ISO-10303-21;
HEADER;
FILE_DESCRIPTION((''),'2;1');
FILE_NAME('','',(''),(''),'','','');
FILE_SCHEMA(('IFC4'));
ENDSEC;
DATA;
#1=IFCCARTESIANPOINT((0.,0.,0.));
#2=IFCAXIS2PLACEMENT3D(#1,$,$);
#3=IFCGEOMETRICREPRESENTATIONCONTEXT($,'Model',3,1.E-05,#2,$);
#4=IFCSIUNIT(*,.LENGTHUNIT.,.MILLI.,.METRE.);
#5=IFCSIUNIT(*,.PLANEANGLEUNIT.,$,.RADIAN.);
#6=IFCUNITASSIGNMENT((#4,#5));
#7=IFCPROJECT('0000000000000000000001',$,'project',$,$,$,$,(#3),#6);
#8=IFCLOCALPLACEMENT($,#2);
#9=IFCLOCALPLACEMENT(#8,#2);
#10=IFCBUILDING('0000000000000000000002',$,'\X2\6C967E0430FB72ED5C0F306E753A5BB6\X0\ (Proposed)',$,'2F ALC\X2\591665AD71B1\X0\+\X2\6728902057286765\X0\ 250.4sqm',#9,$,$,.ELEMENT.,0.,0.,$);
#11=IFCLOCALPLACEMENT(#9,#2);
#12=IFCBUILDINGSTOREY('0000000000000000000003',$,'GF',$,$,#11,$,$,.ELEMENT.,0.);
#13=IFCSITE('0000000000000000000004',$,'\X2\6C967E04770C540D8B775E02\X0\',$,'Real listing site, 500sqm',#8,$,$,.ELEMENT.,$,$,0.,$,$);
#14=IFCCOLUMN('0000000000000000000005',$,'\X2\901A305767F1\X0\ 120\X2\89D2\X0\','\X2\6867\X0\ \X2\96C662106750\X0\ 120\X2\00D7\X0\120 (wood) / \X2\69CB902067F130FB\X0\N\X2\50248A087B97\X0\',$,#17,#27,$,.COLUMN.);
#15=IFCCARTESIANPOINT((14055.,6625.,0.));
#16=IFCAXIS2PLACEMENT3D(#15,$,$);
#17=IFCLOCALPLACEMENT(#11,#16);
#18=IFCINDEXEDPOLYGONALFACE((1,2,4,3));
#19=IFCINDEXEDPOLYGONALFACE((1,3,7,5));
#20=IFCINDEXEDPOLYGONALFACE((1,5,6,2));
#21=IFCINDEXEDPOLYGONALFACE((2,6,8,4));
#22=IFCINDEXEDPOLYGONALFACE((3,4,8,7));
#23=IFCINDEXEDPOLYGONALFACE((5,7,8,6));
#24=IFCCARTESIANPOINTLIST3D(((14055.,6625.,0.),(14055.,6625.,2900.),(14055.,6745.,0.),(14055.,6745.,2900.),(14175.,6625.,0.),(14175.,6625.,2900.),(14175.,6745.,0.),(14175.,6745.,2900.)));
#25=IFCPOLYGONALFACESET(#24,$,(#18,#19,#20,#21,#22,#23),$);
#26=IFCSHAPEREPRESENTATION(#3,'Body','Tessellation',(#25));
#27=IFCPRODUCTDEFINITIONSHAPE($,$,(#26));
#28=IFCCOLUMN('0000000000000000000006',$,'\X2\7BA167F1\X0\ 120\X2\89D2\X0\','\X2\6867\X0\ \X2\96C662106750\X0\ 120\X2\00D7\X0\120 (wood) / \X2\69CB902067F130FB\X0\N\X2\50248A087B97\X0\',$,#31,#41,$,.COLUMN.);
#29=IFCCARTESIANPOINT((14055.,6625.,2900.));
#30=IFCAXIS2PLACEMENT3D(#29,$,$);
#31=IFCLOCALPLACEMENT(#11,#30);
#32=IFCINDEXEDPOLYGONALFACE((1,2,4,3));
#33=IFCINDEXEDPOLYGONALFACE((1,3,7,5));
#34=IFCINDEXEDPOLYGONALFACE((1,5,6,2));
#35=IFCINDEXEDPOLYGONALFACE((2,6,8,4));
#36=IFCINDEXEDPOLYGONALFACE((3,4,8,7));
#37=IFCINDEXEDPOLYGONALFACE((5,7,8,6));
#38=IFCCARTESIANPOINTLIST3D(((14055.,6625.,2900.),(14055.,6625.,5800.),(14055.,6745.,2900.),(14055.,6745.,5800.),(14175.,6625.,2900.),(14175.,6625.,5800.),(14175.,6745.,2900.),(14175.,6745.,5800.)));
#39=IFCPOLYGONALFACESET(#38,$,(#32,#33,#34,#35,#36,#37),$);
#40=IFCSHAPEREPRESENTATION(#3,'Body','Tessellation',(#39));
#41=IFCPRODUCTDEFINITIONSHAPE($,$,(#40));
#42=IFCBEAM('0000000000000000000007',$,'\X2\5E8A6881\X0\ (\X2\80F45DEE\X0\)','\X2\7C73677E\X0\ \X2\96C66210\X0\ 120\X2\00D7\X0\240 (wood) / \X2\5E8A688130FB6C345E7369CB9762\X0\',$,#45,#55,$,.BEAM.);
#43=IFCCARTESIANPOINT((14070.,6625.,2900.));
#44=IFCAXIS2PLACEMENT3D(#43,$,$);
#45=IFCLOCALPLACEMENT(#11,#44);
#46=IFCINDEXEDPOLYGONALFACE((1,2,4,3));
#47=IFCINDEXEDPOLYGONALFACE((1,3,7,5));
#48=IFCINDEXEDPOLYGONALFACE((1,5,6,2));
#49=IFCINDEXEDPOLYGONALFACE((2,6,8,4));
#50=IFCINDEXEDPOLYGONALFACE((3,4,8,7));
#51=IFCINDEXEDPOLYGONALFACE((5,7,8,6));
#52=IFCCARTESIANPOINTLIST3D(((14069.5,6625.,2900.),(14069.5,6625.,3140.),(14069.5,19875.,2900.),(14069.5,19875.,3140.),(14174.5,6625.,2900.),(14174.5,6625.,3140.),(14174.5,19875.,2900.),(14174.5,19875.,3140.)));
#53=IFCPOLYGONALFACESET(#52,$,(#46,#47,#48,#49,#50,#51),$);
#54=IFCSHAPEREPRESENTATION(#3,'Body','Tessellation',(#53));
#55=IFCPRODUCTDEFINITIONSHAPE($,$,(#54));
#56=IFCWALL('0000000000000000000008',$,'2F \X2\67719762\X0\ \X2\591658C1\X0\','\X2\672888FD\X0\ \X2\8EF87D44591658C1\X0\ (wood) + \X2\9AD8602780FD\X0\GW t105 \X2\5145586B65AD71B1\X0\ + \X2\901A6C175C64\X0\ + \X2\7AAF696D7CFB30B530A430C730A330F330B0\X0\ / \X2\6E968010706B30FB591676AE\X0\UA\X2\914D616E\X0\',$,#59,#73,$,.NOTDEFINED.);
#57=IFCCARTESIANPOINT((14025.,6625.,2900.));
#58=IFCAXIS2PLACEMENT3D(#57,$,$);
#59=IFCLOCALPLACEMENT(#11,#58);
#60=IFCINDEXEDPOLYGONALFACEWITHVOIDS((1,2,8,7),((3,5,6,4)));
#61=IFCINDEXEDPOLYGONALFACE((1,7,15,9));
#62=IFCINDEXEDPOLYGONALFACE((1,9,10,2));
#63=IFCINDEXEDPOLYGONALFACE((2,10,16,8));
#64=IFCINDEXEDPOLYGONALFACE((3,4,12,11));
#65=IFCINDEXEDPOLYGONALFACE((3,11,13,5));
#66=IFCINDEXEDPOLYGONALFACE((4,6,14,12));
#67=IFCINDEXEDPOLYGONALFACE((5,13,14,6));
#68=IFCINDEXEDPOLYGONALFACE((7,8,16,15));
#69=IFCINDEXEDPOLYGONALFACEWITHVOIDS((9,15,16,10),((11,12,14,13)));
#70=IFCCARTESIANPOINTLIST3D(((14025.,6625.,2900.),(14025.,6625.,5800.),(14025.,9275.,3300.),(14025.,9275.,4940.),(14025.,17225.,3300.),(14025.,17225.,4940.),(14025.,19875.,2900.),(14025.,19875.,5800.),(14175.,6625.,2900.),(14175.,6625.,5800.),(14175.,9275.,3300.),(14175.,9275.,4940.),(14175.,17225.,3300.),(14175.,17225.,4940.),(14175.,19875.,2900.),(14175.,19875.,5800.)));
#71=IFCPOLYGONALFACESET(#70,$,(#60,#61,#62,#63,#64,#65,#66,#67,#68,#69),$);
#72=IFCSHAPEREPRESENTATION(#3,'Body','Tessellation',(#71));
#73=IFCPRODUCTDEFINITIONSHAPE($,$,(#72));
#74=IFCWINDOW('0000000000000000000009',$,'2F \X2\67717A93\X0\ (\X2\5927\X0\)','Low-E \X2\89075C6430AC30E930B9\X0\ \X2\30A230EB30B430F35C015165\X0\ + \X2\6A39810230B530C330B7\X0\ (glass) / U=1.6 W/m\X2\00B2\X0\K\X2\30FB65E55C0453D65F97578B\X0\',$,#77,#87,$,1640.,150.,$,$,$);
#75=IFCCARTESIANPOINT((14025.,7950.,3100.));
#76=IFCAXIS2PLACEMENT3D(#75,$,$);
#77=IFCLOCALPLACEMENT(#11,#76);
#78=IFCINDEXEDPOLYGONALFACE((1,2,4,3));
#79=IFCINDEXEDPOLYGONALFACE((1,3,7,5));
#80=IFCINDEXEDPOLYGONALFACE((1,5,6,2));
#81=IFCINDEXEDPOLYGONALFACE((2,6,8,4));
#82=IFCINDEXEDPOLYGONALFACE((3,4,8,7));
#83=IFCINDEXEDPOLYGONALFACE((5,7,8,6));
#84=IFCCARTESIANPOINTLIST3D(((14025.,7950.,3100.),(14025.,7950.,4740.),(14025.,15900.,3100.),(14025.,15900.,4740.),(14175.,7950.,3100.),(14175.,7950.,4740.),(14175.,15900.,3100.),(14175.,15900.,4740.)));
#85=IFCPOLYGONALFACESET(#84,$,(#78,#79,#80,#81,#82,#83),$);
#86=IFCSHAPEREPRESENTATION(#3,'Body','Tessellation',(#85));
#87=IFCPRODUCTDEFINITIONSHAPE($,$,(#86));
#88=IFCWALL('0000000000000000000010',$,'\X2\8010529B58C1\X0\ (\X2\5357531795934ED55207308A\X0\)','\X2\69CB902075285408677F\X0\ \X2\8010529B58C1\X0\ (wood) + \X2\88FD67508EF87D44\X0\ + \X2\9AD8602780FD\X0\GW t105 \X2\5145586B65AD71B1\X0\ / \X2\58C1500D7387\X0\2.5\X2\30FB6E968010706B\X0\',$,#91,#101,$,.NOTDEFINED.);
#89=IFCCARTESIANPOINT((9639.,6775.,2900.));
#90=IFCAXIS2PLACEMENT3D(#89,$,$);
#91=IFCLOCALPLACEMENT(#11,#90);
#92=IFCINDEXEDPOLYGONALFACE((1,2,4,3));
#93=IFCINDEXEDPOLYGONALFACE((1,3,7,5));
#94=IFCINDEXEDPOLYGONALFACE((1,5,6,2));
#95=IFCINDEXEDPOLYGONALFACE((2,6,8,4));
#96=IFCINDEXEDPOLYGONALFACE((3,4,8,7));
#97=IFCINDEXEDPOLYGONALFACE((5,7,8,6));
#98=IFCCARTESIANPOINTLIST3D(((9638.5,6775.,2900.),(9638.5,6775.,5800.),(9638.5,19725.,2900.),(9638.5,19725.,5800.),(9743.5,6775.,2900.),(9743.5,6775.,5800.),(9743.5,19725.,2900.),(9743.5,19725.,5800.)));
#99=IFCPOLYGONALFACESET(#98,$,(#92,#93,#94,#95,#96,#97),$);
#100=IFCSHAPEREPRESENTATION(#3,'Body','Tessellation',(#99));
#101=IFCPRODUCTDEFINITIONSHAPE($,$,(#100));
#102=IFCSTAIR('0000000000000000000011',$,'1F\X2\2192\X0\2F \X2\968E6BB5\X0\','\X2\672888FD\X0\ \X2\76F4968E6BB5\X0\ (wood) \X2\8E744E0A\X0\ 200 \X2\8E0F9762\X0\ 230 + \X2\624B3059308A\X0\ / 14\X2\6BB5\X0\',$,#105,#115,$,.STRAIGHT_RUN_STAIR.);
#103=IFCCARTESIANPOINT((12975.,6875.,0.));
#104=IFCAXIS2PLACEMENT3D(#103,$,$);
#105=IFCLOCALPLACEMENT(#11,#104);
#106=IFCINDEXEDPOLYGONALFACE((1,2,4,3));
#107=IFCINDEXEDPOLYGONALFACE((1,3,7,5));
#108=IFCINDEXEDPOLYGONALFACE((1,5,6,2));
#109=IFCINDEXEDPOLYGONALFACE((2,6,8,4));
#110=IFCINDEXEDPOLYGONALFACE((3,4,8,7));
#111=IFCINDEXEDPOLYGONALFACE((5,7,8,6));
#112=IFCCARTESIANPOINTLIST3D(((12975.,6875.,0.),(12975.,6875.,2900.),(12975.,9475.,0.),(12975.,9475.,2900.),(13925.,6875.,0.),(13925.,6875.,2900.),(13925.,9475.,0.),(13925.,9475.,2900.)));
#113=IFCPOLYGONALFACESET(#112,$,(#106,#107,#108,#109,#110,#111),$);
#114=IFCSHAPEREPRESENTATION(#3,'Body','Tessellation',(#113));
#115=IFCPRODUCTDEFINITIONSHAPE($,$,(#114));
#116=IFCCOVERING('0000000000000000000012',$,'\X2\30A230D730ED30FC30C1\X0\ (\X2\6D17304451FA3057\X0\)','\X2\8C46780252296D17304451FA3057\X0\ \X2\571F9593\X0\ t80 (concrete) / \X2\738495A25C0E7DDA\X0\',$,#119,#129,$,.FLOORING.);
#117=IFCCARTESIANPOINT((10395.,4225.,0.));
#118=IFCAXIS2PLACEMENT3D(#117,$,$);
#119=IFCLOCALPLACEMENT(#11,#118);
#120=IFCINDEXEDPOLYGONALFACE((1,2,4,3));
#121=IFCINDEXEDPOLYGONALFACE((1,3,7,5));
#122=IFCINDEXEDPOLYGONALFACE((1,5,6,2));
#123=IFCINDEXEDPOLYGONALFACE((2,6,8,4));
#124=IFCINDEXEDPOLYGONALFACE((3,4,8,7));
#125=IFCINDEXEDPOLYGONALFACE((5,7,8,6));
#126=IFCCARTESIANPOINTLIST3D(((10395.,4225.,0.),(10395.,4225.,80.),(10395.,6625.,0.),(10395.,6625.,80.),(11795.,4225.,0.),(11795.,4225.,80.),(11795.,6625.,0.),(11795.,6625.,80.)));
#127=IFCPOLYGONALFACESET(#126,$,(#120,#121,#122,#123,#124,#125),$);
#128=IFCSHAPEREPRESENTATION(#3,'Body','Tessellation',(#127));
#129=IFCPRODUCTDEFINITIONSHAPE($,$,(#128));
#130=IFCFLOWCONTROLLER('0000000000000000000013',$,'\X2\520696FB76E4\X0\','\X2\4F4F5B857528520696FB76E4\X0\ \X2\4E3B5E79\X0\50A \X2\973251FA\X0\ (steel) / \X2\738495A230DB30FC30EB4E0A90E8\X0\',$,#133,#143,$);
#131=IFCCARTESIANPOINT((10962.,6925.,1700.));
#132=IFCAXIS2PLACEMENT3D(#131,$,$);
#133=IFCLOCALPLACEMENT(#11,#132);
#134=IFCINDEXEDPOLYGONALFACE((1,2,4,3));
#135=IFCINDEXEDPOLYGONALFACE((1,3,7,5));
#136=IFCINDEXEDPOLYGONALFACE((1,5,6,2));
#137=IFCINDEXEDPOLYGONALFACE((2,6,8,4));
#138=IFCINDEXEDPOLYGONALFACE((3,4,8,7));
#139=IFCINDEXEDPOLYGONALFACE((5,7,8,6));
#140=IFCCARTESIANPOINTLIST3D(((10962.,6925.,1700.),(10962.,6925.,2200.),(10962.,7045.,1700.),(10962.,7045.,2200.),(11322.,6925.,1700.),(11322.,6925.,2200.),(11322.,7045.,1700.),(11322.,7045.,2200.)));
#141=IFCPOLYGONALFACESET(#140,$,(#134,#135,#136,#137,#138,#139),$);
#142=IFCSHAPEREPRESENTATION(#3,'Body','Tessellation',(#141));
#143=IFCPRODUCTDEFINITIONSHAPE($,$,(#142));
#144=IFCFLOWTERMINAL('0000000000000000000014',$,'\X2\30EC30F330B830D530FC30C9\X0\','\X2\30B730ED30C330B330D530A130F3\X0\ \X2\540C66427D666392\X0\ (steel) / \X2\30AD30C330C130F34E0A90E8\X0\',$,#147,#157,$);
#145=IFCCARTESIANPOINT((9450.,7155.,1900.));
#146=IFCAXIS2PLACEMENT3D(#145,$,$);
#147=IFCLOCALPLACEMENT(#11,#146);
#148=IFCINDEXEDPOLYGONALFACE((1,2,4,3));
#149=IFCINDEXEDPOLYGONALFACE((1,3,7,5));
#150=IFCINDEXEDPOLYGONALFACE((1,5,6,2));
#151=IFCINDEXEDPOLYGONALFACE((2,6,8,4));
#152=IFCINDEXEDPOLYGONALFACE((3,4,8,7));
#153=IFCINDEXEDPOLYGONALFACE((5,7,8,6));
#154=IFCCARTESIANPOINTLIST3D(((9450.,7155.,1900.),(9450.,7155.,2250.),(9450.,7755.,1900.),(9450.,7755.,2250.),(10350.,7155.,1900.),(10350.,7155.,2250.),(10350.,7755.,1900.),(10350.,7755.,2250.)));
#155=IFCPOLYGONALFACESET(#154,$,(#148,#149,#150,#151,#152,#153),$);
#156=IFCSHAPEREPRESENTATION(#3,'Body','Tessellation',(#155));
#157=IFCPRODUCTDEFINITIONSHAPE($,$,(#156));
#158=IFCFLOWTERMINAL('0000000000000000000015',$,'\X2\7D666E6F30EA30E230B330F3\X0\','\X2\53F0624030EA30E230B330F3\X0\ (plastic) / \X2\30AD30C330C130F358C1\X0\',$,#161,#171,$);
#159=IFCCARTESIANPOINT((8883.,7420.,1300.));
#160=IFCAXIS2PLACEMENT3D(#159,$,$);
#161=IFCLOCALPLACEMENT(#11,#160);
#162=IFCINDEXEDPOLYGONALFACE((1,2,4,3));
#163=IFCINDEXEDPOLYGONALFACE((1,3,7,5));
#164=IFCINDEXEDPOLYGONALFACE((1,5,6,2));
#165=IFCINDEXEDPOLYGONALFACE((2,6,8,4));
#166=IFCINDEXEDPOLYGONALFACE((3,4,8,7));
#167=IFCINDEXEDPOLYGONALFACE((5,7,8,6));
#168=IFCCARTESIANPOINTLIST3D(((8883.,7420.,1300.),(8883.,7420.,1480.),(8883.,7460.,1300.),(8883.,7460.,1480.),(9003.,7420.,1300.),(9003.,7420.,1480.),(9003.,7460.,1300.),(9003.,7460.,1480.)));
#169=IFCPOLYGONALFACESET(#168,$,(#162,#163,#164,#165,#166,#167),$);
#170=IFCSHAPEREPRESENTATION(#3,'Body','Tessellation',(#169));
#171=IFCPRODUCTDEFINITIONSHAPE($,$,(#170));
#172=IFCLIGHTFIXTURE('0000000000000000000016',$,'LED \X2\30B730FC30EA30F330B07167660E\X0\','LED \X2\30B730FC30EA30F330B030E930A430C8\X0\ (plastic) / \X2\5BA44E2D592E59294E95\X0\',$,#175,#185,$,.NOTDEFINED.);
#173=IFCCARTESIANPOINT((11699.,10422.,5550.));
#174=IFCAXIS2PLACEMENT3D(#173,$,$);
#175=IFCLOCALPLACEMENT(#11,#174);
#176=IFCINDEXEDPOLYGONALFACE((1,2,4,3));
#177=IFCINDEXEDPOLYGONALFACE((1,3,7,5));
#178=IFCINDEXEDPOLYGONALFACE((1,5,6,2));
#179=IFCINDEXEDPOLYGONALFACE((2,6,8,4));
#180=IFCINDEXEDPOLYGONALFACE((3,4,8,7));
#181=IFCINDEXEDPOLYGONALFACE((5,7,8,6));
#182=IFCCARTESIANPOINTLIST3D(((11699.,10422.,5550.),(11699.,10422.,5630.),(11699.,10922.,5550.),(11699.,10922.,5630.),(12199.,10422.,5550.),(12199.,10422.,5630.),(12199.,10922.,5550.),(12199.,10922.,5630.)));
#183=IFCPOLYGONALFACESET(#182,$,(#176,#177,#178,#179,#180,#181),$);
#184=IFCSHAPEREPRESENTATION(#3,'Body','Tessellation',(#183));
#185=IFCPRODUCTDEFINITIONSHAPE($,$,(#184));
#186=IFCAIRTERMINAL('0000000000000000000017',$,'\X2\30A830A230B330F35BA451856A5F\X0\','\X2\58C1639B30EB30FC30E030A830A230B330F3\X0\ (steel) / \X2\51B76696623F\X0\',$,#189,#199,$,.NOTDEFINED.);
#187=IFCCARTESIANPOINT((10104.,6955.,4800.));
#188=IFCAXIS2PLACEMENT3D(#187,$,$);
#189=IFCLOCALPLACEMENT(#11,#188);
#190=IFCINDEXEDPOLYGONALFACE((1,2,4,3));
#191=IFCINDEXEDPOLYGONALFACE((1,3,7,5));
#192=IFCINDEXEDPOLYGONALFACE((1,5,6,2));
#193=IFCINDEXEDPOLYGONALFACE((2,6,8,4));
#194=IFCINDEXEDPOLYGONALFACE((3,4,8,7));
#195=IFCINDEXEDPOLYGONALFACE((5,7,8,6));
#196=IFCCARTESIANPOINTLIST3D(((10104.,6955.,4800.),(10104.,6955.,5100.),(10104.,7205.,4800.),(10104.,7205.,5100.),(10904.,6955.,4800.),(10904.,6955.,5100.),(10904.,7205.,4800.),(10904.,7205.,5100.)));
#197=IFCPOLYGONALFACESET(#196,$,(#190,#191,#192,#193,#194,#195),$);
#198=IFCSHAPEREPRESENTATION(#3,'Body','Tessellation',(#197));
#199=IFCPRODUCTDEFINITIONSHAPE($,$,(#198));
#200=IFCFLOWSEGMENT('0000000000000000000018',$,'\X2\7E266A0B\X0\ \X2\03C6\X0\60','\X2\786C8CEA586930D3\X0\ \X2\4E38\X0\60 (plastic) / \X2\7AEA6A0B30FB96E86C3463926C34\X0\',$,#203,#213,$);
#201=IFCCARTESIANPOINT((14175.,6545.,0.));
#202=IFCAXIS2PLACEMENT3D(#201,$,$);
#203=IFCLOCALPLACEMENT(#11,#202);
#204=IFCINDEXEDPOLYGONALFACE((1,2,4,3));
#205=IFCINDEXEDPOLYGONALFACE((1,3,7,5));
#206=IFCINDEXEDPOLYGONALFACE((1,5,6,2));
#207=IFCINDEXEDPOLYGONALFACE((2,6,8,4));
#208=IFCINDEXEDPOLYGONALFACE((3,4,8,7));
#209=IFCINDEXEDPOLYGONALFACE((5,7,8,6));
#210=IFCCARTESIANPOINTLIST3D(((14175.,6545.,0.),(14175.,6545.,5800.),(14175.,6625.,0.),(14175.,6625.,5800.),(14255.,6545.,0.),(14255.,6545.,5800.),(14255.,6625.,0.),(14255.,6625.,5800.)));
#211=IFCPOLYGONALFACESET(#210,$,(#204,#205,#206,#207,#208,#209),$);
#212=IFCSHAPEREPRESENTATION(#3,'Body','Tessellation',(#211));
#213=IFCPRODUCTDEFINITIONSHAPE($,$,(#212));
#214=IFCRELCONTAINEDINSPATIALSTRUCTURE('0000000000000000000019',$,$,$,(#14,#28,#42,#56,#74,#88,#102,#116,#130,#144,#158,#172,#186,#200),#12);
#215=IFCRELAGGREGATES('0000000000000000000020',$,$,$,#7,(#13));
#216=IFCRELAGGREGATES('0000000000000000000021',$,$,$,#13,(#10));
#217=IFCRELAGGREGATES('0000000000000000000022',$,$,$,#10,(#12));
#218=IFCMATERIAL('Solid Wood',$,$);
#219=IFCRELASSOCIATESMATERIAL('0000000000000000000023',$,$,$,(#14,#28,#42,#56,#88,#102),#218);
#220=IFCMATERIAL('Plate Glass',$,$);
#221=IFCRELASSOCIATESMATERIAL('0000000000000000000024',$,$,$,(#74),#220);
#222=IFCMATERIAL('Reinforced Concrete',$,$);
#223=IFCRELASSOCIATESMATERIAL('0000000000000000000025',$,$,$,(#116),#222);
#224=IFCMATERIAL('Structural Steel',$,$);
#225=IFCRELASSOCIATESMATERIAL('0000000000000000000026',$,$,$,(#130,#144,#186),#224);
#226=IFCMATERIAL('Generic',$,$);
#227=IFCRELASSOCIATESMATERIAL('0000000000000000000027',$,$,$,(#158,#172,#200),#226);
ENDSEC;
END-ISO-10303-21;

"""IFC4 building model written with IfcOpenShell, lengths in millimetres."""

from ifc_helpers import new_model, si_unit, frame, frame_2d, origin, place, context, project, spatial, rectangle, extrude, material, element, fill, save


model = new_model("IFC4")

# Units and contexts
model_context = context("Model", 3, precision=1e-05, world=origin())
ifc_project = project(units=[si_unit("LENGTHUNIT", "METRE", prefix="MILLI"), si_unit("PLANEANGLEUNIT", "RADIAN")], contexts=[model_context])

# Site, building, storey
site_placement = place(None, origin())
site = spatial("IfcSite", under=ifc_project, at=site_placement, Name="沖縄県名護市", ObjectType="Real listing site, 500sqm", CompositionType="ELEMENT", RefElevation=0.0)
building_placement = place(site_placement, origin())
building = spatial("IfcBuilding", under=site, at=building_placement, Name="沖縄・狭小の町家 (Proposed)", ObjectType="2F ALC外断熱+木造在来 250.4sqm", CompositionType="ELEMENT", ElevationOfRefHeight=0.0, ElevationOfTerrain=0.0)
storey_placement = place(building_placement, origin())
storey = spatial("IfcBuildingStorey", under=building, at=storey_placement, Name="GF", CompositionType="ELEMENT", Elevation=0.0)

# Columns
ifc_material_1 = material(Name="Solid Wood")
column_1_placement = place(storey_placement, frame((14055.0, 6625.0, 0.0)))
element("IfcColumn", 1, at=column_1_placement, inside=storey, material=ifc_material_1, Name="通し柱 120角", Description="桧 集成材 120×120 (wood) / 構造柱・N値計算", PredefinedType="COLUMN", context=model_context, shape_type="SweptSolid", body=[
    extrude(rectangle(XDim=120.0, YDim=120.0, at=frame_2d((60.0, 60.0))), frame((14055.0, 6625.0, 0.0)), (0.0, 0.0, 1.0), 2900.0),
])
column_2_placement = place(storey_placement, frame((14055.0, 6625.0, 2900.0)))
element("IfcColumn", 2, at=column_2_placement, inside=storey, material=ifc_material_1, Name="管柱 120角", Description="桧 集成材 120×120 (wood) / 構造柱・N値計算", PredefinedType="COLUMN", context=model_context, shape_type="SweptSolid", body=[
    extrude(rectangle(XDim=120.0, YDim=120.0, at=frame_2d((60.0, 60.0))), frame((14055.0, 6625.0, 2900.0)), (0.0, 0.0, 1.0), 2900.0),
])

# Beam
beam_1_placement = place(storey_placement, frame((14070.0, 6625.0, 2900.0)))
element("IfcBeam", 3, at=beam_1_placement, inside=storey, material=ifc_material_1, Name="床梁 (胴差)", Description="米松 集成 120×240 (wood) / 床梁・水平構面", PredefinedType="BEAM", context=model_context, shape_type="SweptSolid", body=[
    extrude(rectangle(XDim=105.0, YDim=13250.0, at=frame_2d((52.0, 6625.0))), frame((14070.0, 6625.0, 2900.0)), (0.0, 0.0, 1.0), 240.0),
])

# Shared definitions
ifc_material_2 = material(Name="Plate Glass")

# Wall, opening, window
wall_1_placement = place(storey_placement, frame((14025.0, 6625.0, 2900.0)))
wall_1 = element("IfcWall", 4, at=wall_1_placement, inside=storey, material=ifc_material_1, Name="2F 東面 外壁", Description="木製 軸組外壁 (wood) + 高性能GW t105 充填断熱 + 通気層 + 窯業系サイディング / 準耐火・外皮UA配慮", PredefinedType="NOTDEFINED", context=model_context, shape_type="SweptSolid", body=[
    extrude(rectangle(XDim=150.0, YDim=13250.0, at=frame_2d((75.0, 6625.0))), frame((14025.0, 6625.0, 2900.0)), (0.0, 0.0, 1.0), 2900.0),
])
opening_1_placement = place(storey_placement, frame((14025.0, 7950.0, 3100.0)))
opening_1 = element("IfcOpeningElement", 5, at=opening_1_placement, cuts=wall_1, PredefinedType="NOTDEFINED", context=model_context, shape_type="SweptSolid", body=[
    extrude(rectangle(XDim=150.0, YDim=7950.0, at=frame_2d((75.0, 3975.0))), frame((14025.0, 7950.0, 3100.0)), (0.0, 0.0, 1.0), 1640.0),
])
window_1_placement = place(storey_placement, frame((14025.0, 7950.0, 3100.0)))
window_1 = element("IfcWindow", 6, at=window_1_placement, inside=storey, material=ifc_material_2, Name="2F 東窓 (大)", Description="Low-E 複層ガラス アルゴン封入 + 樹脂サッシ (glass) / U=1.6 W/m²K・日射取得型", OverallHeight=1640.0, OverallWidth=150.0, context=model_context, shape_type="SweptSolid", body=[
    extrude(rectangle(XDim=150.0, YDim=7950.0, at=frame_2d((75.0, 3975.0))), frame((14025.0, 7950.0, 3100.0)), (0.0, 0.0, 1.0), 1640.0),
])
fill(opening_1, window_1)

# Wall
wall_2_placement = place(storey_placement, frame((9639.0, 6775.0, 2900.0)))
element("IfcWall", 7, at=wall_2_placement, inside=storey, material=ifc_material_1, Name="耐力壁 (南北間仕切り)", Description="構造用合板 耐力壁 (wood) + 製材軸組 + 高性能GW t105 充填断熱 / 壁倍率2.5・準耐火", PredefinedType="NOTDEFINED", context=model_context, shape_type="SweptSolid", body=[
    extrude(rectangle(XDim=105.0, YDim=12950.0, at=frame_2d((52.0, 6475.0))), frame((9639.0, 6775.0, 2900.0)), (0.0, 0.0, 1.0), 2900.0),
])

# Stair
stair_placement = place(storey_placement, frame((12975.0, 6875.0, 0.0)))
element("IfcStair", 8, at=stair_placement, inside=storey, material=ifc_material_1, Name="1F→2F 階段", Description="木製 直階段 (wood) 蹴上 200 踏面 230 + 手すり / 14段", PredefinedType="STRAIGHT_RUN_STAIR", context=model_context, shape_type="SweptSolid", body=[
    extrude(rectangle(XDim=950.0, YDim=2600.0, at=frame_2d((475.0, 1300.0))), frame((12975.0, 6875.0, 0.0)), (0.0, 0.0, 1.0), 2900.0),
])

# Covering
ifc_material_3 = material(Name="Reinforced Concrete")
covering_placement = place(storey_placement, frame((10395.0, 4225.0, 0.0)))
element("IfcCovering", 9, at=covering_placement, inside=storey, material=ifc_material_3, Name="アプローチ (洗い出し)", Description="豆砂利洗い出し 土間 t80 (concrete) / 玄関導線", PredefinedType="FLOORING", context=model_context, shape_type="SweptSolid", body=[
    extrude(rectangle(XDim=1400.0, YDim=2400.0, at=frame_2d((700.0, 1200.0))), frame((10395.0, 4225.0, 0.0)), (0.0, 0.0, 1.0), 80.0),
])

# Flow controller
ifc_material_4 = material(Name="Structural Steel")
flow_controller_placement = place(storey_placement, frame((10962.0, 6925.0, 1700.0)))
element("IfcFlowController", 10, at=flow_controller_placement, inside=storey, material=ifc_material_4, Name="分電盤", Description="住宅用分電盤 主幹50A 露出 (steel) / 玄関ホール上部", context=model_context, shape_type="SweptSolid", body=[
    extrude(rectangle(XDim=360.0, YDim=120.0, at=frame_2d((180.0, 60.0))), frame((10962.0, 6925.0, 1700.0)), (0.0, 0.0, 1.0), 500.0),
])

# Flow terminals
flow_terminal_1_placement = place(storey_placement, frame((9450.0, 7155.0, 1900.0)))
element("IfcFlowTerminal", 11, at=flow_terminal_1_placement, inside=storey, material=ifc_material_4, Name="レンジフード", Description="シロッコファン 同時給排 (steel) / キッチン上部", context=model_context, shape_type="SweptSolid", body=[
    extrude(rectangle(XDim=900.0, YDim=600.0, at=frame_2d((450.0, 300.0))), frame((9450.0, 7155.0, 1900.0)), (0.0, 0.0, 1.0), 350.0),
])
ifc_material_5 = material(Name="Generic")
flow_terminal_2_placement = place(storey_placement, frame((8883.0, 7420.0, 1300.0)))
element("IfcFlowTerminal", 12, at=flow_terminal_2_placement, inside=storey, material=ifc_material_5, Name="給湯リモコン", Description="台所リモコン (plastic) / キッチン壁", context=model_context, shape_type="SweptSolid", body=[
    extrude(rectangle(XDim=120.0, YDim=40.0, at=frame_2d((60.0, 20.0))), frame((8883.0, 7420.0, 1300.0)), (0.0, 0.0, 1.0), 180.0),
])

# Light fixture
light_fixture_placement = place(storey_placement, frame((11699.0, 10422.0, 5550.0)))
element("IfcLightFixture", 13, at=light_fixture_placement, inside=storey, material=ifc_material_5, Name="LED シーリング照明", Description="LED シーリングライト (plastic) / 室中央天井", PredefinedType="NOTDEFINED", context=model_context, shape_type="SweptSolid", body=[
    extrude(rectangle(XDim=500.0, YDim=500.0, at=frame_2d((250.0, 250.0))), frame((11699.0, 10422.0, 5550.0)), (0.0, 0.0, 1.0), 80.0),
])

# Air terminal
air_terminal_placement = place(storey_placement, frame((10104.0, 6955.0, 4800.0)))
element("IfcAirTerminal", 14, at=air_terminal_placement, inside=storey, material=ifc_material_4, Name="エアコン室内機", Description="壁掛ルームエアコン (steel) / 冷暖房", PredefinedType="NOTDEFINED", context=model_context, shape_type="SweptSolid", body=[
    extrude(rectangle(XDim=800.0, YDim=250.0, at=frame_2d((400.0, 125.0))), frame((10104.0, 6955.0, 4800.0)), (0.0, 0.0, 1.0), 300.0),
])

# Flow segment
flow_segment_placement = place(storey_placement, frame((14175.0, 6545.0, 0.0)))
element("IfcFlowSegment", 15, at=flow_segment_placement, inside=storey, material=ifc_material_5, Name="縦樋 φ60", Description="硬質塩ビ 丸60 (plastic) / 竪樋・雨水排水", context=model_context, shape_type="SweptSolid", body=[
    extrude(rectangle(XDim=80.0, YDim=80.0, at=frame_2d((40.0, 40.0))), frame((14175.0, 6545.0, 0.0)), (0.0, 0.0, 1.0), 5800.0),
])

save(model, "model.ifc")
